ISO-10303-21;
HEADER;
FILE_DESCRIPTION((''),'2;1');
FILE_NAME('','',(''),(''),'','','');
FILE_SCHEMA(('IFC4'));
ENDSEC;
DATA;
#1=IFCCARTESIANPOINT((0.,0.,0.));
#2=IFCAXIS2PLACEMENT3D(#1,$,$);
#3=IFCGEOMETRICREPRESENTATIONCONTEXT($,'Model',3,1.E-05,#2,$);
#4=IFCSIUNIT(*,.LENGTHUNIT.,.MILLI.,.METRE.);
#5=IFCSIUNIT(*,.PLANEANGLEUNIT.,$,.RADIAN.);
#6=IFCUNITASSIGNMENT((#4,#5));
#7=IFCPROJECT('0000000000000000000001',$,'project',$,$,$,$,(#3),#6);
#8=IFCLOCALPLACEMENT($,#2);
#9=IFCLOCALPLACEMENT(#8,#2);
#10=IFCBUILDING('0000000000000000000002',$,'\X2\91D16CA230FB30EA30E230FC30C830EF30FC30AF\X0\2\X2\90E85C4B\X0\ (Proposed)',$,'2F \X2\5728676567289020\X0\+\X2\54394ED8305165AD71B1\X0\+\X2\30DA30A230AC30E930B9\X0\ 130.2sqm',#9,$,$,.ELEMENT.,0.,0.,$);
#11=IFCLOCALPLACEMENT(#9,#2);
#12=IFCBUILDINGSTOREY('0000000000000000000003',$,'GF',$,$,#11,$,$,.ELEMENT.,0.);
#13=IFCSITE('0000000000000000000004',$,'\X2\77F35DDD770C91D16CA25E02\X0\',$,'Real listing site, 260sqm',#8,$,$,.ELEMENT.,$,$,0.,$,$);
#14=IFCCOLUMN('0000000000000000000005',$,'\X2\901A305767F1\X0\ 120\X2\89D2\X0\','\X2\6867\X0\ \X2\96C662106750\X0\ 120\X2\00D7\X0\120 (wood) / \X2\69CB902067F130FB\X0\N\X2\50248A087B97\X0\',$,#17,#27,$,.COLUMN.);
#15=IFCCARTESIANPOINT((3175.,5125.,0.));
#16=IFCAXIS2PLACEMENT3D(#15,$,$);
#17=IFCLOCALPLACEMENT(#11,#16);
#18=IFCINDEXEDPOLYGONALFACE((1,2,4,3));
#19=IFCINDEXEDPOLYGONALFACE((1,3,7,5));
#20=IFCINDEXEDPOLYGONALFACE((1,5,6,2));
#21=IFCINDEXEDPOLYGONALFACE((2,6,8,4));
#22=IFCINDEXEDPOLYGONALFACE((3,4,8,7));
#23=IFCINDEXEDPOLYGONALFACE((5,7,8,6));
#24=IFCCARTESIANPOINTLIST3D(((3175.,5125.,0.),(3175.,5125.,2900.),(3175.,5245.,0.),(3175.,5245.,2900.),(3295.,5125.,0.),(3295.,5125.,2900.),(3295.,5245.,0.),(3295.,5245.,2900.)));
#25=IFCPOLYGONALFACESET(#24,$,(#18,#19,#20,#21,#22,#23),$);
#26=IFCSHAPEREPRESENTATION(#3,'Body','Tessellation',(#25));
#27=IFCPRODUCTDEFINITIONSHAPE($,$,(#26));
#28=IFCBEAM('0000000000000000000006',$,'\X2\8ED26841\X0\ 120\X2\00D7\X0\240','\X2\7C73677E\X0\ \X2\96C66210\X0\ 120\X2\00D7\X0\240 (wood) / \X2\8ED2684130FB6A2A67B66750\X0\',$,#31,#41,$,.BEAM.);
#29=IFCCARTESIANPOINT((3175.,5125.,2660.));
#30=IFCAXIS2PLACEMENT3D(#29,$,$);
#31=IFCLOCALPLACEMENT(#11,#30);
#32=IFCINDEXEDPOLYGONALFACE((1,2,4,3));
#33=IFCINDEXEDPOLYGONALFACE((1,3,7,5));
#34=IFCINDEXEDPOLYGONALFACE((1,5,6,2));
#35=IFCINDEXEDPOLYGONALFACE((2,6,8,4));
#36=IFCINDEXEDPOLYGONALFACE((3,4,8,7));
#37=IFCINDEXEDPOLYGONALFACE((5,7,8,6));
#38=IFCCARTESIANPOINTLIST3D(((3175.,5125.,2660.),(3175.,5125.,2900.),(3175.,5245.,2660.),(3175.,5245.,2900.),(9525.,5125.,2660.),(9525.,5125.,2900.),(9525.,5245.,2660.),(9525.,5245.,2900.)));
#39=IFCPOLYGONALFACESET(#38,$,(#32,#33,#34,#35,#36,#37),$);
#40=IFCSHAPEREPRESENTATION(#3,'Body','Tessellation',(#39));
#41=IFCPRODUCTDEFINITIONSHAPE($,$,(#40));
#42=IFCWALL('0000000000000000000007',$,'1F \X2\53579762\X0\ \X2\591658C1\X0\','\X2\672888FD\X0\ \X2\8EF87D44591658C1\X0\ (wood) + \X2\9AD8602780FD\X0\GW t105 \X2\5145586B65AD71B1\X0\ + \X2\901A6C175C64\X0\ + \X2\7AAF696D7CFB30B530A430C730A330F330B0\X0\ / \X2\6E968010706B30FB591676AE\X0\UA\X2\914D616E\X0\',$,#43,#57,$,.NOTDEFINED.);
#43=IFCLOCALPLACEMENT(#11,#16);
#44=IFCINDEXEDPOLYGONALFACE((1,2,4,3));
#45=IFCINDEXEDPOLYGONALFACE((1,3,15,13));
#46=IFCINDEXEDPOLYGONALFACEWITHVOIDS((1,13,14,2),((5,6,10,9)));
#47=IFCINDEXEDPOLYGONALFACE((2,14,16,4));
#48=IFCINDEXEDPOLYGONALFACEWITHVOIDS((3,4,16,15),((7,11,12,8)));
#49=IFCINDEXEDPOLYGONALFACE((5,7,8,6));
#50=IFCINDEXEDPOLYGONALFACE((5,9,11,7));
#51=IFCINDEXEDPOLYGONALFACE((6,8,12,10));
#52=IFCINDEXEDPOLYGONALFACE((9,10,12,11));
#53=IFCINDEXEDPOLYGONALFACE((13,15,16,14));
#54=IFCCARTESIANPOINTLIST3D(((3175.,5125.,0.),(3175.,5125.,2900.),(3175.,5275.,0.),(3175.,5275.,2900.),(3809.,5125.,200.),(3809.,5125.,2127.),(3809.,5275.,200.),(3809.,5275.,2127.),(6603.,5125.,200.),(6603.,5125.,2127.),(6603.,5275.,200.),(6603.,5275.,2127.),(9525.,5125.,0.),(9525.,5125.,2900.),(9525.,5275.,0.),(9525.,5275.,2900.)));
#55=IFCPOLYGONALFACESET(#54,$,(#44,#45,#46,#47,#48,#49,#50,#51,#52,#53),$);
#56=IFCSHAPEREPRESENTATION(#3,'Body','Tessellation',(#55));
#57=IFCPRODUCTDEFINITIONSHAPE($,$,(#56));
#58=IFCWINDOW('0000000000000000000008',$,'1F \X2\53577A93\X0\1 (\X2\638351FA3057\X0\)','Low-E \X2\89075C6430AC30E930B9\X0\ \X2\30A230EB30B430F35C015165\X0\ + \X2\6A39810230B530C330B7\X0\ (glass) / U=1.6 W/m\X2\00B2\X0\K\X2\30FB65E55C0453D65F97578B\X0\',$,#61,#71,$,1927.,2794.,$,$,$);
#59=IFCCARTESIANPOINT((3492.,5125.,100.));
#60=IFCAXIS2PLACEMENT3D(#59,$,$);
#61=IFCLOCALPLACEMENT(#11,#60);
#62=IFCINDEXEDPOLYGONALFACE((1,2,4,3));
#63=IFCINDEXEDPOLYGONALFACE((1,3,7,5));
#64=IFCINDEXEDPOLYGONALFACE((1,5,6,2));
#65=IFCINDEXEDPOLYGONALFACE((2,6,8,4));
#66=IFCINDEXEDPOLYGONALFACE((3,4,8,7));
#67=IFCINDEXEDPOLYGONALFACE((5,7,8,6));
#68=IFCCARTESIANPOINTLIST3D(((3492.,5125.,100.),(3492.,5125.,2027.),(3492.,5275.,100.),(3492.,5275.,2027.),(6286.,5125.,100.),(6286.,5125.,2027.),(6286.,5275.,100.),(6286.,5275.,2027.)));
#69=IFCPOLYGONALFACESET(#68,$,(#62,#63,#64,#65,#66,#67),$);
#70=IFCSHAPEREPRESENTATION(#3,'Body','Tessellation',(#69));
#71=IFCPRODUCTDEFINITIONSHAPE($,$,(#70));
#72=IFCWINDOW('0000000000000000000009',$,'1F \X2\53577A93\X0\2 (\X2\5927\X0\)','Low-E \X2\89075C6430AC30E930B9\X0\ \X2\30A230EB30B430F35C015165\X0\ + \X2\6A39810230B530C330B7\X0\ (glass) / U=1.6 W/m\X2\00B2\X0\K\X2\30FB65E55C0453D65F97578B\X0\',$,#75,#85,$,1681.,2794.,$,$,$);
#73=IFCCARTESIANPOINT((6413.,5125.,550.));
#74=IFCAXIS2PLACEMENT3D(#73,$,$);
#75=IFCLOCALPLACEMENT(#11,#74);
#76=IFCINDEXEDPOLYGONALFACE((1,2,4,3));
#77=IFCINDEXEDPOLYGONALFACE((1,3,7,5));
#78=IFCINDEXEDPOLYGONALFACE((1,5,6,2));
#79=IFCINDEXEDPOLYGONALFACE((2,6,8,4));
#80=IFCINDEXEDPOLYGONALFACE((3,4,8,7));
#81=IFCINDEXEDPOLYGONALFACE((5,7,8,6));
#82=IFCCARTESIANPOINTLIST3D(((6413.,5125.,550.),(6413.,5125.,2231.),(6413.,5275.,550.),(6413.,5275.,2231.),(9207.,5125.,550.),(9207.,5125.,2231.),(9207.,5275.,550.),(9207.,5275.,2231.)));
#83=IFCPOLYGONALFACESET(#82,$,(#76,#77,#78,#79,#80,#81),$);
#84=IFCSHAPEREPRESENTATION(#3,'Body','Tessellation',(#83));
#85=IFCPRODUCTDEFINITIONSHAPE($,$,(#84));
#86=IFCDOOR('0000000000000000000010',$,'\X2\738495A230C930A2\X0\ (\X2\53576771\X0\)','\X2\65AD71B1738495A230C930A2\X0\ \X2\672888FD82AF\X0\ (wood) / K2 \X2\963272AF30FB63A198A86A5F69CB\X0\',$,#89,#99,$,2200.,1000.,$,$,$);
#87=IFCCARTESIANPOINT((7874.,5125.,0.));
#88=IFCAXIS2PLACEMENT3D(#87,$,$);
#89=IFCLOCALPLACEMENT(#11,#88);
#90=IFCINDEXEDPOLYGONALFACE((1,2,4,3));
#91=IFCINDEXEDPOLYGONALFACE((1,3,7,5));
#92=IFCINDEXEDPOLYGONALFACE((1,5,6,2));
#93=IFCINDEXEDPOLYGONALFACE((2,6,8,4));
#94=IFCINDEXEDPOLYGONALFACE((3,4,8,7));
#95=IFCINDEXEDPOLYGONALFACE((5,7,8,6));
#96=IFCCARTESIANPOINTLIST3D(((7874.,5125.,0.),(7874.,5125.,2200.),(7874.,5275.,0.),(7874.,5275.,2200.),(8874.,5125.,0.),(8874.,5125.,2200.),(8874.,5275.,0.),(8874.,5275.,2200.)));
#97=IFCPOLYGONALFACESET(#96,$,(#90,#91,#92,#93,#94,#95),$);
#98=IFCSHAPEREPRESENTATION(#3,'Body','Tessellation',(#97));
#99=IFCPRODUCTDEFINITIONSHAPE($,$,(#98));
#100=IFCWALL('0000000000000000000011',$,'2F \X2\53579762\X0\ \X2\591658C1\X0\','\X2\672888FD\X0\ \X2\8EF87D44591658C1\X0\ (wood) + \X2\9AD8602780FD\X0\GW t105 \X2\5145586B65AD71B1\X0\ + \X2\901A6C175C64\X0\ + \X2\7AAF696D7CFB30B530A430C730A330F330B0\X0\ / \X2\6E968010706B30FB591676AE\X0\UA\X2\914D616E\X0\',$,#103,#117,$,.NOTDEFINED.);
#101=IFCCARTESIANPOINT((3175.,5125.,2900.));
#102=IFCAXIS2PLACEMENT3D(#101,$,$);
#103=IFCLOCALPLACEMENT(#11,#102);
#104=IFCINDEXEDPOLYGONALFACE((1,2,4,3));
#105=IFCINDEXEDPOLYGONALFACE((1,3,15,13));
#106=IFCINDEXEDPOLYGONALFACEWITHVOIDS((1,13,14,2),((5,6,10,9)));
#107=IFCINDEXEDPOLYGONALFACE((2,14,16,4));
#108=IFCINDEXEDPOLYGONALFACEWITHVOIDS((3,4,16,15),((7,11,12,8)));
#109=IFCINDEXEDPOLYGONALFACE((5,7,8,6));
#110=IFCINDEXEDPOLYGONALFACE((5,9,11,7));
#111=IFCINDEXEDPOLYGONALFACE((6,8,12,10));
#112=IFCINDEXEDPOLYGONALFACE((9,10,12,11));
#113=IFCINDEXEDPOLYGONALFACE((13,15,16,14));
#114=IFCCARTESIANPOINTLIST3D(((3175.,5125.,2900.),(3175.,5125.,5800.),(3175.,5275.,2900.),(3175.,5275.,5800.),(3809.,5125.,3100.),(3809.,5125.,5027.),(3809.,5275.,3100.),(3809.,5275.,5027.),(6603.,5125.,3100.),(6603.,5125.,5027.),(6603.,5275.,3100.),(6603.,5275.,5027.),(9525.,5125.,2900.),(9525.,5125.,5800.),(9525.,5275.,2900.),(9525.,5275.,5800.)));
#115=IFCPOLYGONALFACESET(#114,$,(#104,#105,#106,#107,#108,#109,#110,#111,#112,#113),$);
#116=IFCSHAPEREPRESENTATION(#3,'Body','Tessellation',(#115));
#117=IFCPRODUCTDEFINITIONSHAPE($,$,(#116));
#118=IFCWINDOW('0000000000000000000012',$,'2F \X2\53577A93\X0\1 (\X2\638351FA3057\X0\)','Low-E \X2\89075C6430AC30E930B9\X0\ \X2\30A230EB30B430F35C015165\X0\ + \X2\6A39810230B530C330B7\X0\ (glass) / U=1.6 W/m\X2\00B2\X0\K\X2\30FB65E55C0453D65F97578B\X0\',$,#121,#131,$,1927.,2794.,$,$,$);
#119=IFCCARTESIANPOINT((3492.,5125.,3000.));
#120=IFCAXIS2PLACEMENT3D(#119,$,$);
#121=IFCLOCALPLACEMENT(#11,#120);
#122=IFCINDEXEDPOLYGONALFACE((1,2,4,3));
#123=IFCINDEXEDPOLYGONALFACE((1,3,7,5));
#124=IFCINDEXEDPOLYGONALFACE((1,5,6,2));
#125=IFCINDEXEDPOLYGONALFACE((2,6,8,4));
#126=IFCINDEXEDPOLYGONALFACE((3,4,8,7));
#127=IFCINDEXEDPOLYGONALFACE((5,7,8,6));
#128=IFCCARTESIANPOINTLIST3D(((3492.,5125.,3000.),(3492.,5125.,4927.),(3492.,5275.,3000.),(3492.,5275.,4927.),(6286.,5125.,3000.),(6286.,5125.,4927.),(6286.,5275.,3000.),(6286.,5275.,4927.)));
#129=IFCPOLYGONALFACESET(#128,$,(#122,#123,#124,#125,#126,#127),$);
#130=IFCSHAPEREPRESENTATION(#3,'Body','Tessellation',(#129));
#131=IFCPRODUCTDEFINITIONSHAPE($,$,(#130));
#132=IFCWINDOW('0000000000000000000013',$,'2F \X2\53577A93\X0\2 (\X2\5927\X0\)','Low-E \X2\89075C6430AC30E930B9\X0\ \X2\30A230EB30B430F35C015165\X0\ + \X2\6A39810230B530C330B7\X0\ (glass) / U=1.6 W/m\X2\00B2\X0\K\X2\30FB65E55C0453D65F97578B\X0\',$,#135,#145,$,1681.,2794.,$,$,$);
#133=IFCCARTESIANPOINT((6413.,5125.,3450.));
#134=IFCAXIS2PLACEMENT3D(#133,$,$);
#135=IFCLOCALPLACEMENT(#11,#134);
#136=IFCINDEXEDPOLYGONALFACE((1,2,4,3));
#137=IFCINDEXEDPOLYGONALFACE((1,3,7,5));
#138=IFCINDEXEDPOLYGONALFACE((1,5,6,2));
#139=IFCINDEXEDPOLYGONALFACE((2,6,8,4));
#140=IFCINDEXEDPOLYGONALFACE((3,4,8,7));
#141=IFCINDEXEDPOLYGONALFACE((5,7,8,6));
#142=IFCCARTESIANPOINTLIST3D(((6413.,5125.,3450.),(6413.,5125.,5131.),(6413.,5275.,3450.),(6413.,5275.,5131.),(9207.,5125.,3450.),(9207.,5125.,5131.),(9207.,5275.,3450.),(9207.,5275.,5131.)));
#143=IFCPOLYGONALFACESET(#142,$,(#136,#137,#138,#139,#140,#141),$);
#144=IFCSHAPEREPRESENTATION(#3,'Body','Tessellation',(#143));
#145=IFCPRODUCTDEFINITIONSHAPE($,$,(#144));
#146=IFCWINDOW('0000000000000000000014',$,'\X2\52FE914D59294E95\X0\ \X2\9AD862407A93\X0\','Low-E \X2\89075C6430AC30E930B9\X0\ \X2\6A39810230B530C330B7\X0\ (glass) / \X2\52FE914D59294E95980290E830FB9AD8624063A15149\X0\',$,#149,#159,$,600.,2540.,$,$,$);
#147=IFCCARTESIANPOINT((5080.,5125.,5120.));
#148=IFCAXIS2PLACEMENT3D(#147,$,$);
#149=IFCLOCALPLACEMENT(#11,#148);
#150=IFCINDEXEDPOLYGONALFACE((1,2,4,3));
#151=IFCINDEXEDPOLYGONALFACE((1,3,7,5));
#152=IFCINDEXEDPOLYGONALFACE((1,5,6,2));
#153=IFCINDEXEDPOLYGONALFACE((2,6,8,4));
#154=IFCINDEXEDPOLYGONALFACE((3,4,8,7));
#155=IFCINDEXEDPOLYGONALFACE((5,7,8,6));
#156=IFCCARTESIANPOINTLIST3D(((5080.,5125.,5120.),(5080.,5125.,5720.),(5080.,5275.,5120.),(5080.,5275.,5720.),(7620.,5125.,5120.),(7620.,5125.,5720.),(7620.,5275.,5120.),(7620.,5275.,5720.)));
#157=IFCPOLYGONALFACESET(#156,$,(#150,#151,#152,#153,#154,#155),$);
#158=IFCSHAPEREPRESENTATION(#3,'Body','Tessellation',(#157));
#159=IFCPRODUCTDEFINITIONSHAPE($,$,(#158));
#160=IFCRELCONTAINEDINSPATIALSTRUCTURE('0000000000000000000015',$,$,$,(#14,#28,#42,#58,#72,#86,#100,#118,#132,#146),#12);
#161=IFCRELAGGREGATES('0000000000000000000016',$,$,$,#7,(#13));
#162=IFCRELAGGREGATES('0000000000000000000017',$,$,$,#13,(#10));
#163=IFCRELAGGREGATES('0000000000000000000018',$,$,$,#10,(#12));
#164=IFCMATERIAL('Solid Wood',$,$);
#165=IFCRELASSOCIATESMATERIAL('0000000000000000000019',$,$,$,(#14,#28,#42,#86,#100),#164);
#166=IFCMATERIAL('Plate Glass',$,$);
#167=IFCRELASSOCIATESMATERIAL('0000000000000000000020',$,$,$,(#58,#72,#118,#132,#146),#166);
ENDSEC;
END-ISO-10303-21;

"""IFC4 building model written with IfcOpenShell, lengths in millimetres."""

from ifc_helpers import new_model, si_unit, frame, frame_2d, origin, place, context, project, spatial, rectangle, extrude, material, element, fill, save


model = new_model("IFC4")

# Units and contexts
model_context = context("Model", 3, precision=1e-05, world=origin())
ifc_project = project(units=[si_unit("LENGTHUNIT", "METRE", prefix="MILLI"), si_unit("PLANEANGLEUNIT", "RADIAN")], contexts=[model_context])

# Site, building, storey
site_placement = place(None, origin())
site = spatial("IfcSite", under=ifc_project, at=site_placement, Name="石川県金沢市", ObjectType="Real listing site, 260sqm", CompositionType="ELEMENT", RefElevation=0.0)
building_placement = place(site_placement, origin())
building = spatial("IfcBuilding", under=site, at=building_placement, Name="金沢・リモートワーク2部屋 (Proposed)", ObjectType="2F 在来木造+吹付け断熱+ペアガラス 130.2sqm", CompositionType="ELEMENT", ElevationOfRefHeight=0.0, ElevationOfTerrain=0.0)
storey_placement = place(building_placement, origin())
storey = spatial("IfcBuildingStorey", under=building, at=storey_placement, Name="GF", CompositionType="ELEMENT", Elevation=0.0)

# Column
ifc_material_1 = material(Name="Solid Wood")
column_placement = place(storey_placement, frame((3175.0, 5125.0, 0.0)))
element("IfcColumn", 1, at=column_placement, inside=storey, material=ifc_material_1, Name="通し柱 120角", Description="桧 集成材 120×120 (wood) / 構造柱・N値計算", PredefinedType="COLUMN", context=model_context, shape_type="SweptSolid", body=[
    extrude(rectangle(XDim=120.0, YDim=120.0, at=frame_2d((60.0, 60.0))), frame((3175.0, 5125.0, 0.0)), (0.0, 0.0, 1.0), 2900.0),
])

# Beam
beam_1_placement = place(storey_placement, frame((3175.0, 5125.0, 2660.0)))
element("IfcBeam", 2, at=beam_1_placement, inside=storey, material=ifc_material_1, Name="軒桁 120×240", Description="米松 集成 120×240 (wood) / 軒桁・横架材", PredefinedType="BEAM", context=model_context, shape_type="SweptSolid", body=[
    extrude(rectangle(XDim=6350.0, YDim=120.0, at=frame_2d((3175.0, 60.0))), frame((3175.0, 5125.0, 2660.0)), (0.0, 0.0, 1.0), 240.0),
])

# Wall, openings, windows, door
wall_1_placement = place(storey_placement, frame((3175.0, 5125.0, 0.0)))
wall_1 = element("IfcWall", 3, at=wall_1_placement, inside=storey, material=ifc_material_1, Name="1F 南面 外壁", Description="木製 軸組外壁 (wood) + 高性能GW t105 充填断熱 + 通気層 + 窯業系サイディング / 準耐火・外皮UA配慮", PredefinedType="NOTDEFINED", context=model_context, shape_type="SweptSolid", body=[
    extrude(rectangle(XDim=6350.0, YDim=150.0, at=frame_2d((3175.0, 75.0))), frame((3175.0, 5125.0, 0.0)), (0.0, 0.0, 1.0), 2900.0),
])
opening_1_placement = place(storey_placement, frame((3492.0, 5125.0, 100.0)))
opening_1 = element("IfcOpeningElement", 4, at=opening_1_placement, cuts=wall_1, PredefinedType="NOTDEFINED", context=model_context, shape_type="SweptSolid", body=[
    extrude(rectangle(XDim=2794.0, YDim=150.0, at=frame_2d((1397.0, 75.0))), frame((3492.0, 5125.0, 100.0)), (0.0, 0.0, 1.0), 1927.0),
])
opening_2_placement = place(storey_placement, frame((6413.0, 5125.0, 550.0)))
opening_2 = element("IfcOpeningElement", 5, at=opening_2_placement, cuts=wall_1, PredefinedType="NOTDEFINED", context=model_context, shape_type="SweptSolid", body=[
    extrude(rectangle(XDim=2794.0, YDim=150.0, at=frame_2d((1397.0, 75.0))), frame((6413.0, 5125.0, 550.0)), (0.0, 0.0, 1.0), 1681.0),
])
opening_3_placement = place(storey_placement, frame((7874.0, 5125.0, 0.0)))
opening_3 = element("IfcOpeningElement", 6, at=opening_3_placement, cuts=wall_1, PredefinedType="NOTDEFINED", context=model_context, shape_type="SweptSolid", body=[
    extrude(rectangle(XDim=1000.0, YDim=150.0, at=frame_2d((500.0, 75.0))), frame((7874.0, 5125.0, 0.0)), (0.0, 0.0, 1.0), 2200.0),
])
ifc_material_2 = material(Name="Plate Glass")
window_1_placement = place(storey_placement, frame((3492.0, 5125.0, 100.0)))
window_1 = element("IfcWindow", 7, at=window_1_placement, inside=storey, material=ifc_material_2, Name="1F 南窓1 (掃出し)", Description="Low-E 複層ガラス アルゴン封入 + 樹脂サッシ (glass) / U=1.6 W/m²K・日射取得型", OverallHeight=1927.0, OverallWidth=2794.0, context=model_context, shape_type="SweptSolid", body=[
    extrude(rectangle(XDim=2794.0, YDim=150.0, at=frame_2d((1397.0, 75.0))), frame((3492.0, 5125.0, 100.0)), (0.0, 0.0, 1.0), 1927.0),
])
fill(opening_1, window_1)
window_2_placement = place(storey_placement, frame((6413.0, 5125.0, 550.0)))
window_2 = element("IfcWindow", 8, at=window_2_placement, inside=storey, material=ifc_material_2, Name="1F 南窓2 (大)", Description="Low-E 複層ガラス アルゴン封入 + 樹脂サッシ (glass) / U=1.6 W/m²K・日射取得型", OverallHeight=1681.0, OverallWidth=2794.0, context=model_context, shape_type="SweptSolid", body=[
    extrude(rectangle(XDim=2794.0, YDim=150.0, at=frame_2d((1397.0, 75.0))), frame((6413.0, 5125.0, 550.0)), (0.0, 0.0, 1.0), 1681.0),
])
fill(opening_2, window_2)
door_placement = place(storey_placement, frame((7874.0, 5125.0, 0.0)))
door = element("IfcDoor", 9, at=door_placement, inside=storey, material=ifc_material_1, Name="玄関ドア (南東)", Description="断熱玄関ドア 木製芯 (wood) / K2 防犯・採風機構", OverallHeight=2200.0, OverallWidth=1000.0, context=model_context, shape_type="SweptSolid", body=[
    extrude(rectangle(XDim=1000.0, YDim=150.0, at=frame_2d((500.0, 75.0))), frame((7874.0, 5125.0, 0.0)), (0.0, 0.0, 1.0), 2200.0),
])
fill(opening_3, door)

# Wall, openings, windows
wall_2_placement = place(storey_placement, frame((3175.0, 5125.0, 2900.0)))
wall_2 = element("IfcWall", 10, at=wall_2_placement, inside=storey, material=ifc_material_1, Name="2F 南面 外壁", Description="木製 軸組外壁 (wood) + 高性能GW t105 充填断熱 + 通気層 + 窯業系サイディング / 準耐火・外皮UA配慮", PredefinedType="NOTDEFINED", context=model_context, shape_type="SweptSolid", body=[
    extrude(rectangle(XDim=6350.0, YDim=150.0, at=frame_2d((3175.0, 75.0))), frame((3175.0, 5125.0, 2900.0)), (0.0, 0.0, 1.0), 2900.0),
])
opening_4_placement = place(storey_placement, frame((3492.0, 5125.0, 3000.0)))
opening_4 = element("IfcOpeningElement", 11, at=opening_4_placement, cuts=wall_2, PredefinedType="NOTDEFINED", context=model_context, shape_type="SweptSolid", body=[
    extrude(rectangle(XDim=2794.0, YDim=150.0, at=frame_2d((1397.0, 75.0))), frame((3492.0, 5125.0, 3000.0)), (0.0, 0.0, 1.0), 1927.0),
])
opening_5_placement = place(storey_placement, frame((6413.0, 5125.0, 3450.0)))
opening_5 = element("IfcOpeningElement", 12, at=opening_5_placement, cuts=wall_2, PredefinedType="NOTDEFINED", context=model_context, shape_type="SweptSolid", body=[
    extrude(rectangle(XDim=2794.0, YDim=150.0, at=frame_2d((1397.0, 75.0))), frame((6413.0, 5125.0, 3450.0)), (0.0, 0.0, 1.0), 1681.0),
])
opening_6_placement = place(storey_placement, frame((5080.0, 5125.0, 5120.0)))
opening_6 = element("IfcOpeningElement", 13, at=opening_6_placement, cuts=wall_2, PredefinedType="NOTDEFINED", context=model_context, shape_type="SweptSolid", body=[
    extrude(rectangle(XDim=2540.0, YDim=150.0, at=frame_2d((1270.0, 75.0))), frame((5080.0, 5125.0, 5120.0)), (0.0, 0.0, 1.0), 600.0),
])
window_3_placement = place(storey_placement, frame((3492.0, 5125.0, 3000.0)))
window_3 = element("IfcWindow", 14, at=window_3_placement, inside=storey, material=ifc_material_2, Name="2F 南窓1 (掃出し)", Description="Low-E 複層ガラス アルゴン封入 + 樹脂サッシ (glass) / U=1.6 W/m²K・日射取得型", OverallHeight=1927.0, OverallWidth=2794.0, context=model_context, shape_type="SweptSolid", body=[
    extrude(rectangle(XDim=2794.0, YDim=150.0, at=frame_2d((1397.0, 75.0))), frame((3492.0, 5125.0, 3000.0)), (0.0, 0.0, 1.0), 1927.0),
])
fill(opening_4, window_3)
window_4_placement = place(storey_placement, frame((6413.0, 5125.0, 3450.0)))
window_4 = element("IfcWindow", 15, at=window_4_placement, inside=storey, material=ifc_material_2, Name="2F 南窓2 (大)", Description="Low-E 複層ガラス アルゴン封入 + 樹脂サッシ (glass) / U=1.6 W/m²K・日射取得型", OverallHeight=1681.0, OverallWidth=2794.0, context=model_context, shape_type="SweptSolid", body=[
    extrude(rectangle(XDim=2794.0, YDim=150.0, at=frame_2d((1397.0, 75.0))), frame((6413.0, 5125.0, 3450.0)), (0.0, 0.0, 1.0), 1681.0),
])
fill(opening_5, window_4)
window_5_placement = place(storey_placement, frame((5080.0, 5125.0, 5120.0)))
window_5 = element("IfcWindow", 16, at=window_5_placement, inside=storey, material=ifc_material_2, Name="勾配天井 高所窓", Description="Low-E 複層ガラス 樹脂サッシ (glass) / 勾配天井頂部・高所採光", OverallHeight=600.0, OverallWidth=2540.0, context=model_context, shape_type="SweptSolid", body=[
    extrude(rectangle(XDim=2540.0, YDim=150.0, at=frame_2d((1270.0, 75.0))), frame((5080.0, 5125.0, 5120.0)), (0.0, 0.0, 1.0), 600.0),
])
fill(opening_6, window_5)

save(model, "model.ifc")
